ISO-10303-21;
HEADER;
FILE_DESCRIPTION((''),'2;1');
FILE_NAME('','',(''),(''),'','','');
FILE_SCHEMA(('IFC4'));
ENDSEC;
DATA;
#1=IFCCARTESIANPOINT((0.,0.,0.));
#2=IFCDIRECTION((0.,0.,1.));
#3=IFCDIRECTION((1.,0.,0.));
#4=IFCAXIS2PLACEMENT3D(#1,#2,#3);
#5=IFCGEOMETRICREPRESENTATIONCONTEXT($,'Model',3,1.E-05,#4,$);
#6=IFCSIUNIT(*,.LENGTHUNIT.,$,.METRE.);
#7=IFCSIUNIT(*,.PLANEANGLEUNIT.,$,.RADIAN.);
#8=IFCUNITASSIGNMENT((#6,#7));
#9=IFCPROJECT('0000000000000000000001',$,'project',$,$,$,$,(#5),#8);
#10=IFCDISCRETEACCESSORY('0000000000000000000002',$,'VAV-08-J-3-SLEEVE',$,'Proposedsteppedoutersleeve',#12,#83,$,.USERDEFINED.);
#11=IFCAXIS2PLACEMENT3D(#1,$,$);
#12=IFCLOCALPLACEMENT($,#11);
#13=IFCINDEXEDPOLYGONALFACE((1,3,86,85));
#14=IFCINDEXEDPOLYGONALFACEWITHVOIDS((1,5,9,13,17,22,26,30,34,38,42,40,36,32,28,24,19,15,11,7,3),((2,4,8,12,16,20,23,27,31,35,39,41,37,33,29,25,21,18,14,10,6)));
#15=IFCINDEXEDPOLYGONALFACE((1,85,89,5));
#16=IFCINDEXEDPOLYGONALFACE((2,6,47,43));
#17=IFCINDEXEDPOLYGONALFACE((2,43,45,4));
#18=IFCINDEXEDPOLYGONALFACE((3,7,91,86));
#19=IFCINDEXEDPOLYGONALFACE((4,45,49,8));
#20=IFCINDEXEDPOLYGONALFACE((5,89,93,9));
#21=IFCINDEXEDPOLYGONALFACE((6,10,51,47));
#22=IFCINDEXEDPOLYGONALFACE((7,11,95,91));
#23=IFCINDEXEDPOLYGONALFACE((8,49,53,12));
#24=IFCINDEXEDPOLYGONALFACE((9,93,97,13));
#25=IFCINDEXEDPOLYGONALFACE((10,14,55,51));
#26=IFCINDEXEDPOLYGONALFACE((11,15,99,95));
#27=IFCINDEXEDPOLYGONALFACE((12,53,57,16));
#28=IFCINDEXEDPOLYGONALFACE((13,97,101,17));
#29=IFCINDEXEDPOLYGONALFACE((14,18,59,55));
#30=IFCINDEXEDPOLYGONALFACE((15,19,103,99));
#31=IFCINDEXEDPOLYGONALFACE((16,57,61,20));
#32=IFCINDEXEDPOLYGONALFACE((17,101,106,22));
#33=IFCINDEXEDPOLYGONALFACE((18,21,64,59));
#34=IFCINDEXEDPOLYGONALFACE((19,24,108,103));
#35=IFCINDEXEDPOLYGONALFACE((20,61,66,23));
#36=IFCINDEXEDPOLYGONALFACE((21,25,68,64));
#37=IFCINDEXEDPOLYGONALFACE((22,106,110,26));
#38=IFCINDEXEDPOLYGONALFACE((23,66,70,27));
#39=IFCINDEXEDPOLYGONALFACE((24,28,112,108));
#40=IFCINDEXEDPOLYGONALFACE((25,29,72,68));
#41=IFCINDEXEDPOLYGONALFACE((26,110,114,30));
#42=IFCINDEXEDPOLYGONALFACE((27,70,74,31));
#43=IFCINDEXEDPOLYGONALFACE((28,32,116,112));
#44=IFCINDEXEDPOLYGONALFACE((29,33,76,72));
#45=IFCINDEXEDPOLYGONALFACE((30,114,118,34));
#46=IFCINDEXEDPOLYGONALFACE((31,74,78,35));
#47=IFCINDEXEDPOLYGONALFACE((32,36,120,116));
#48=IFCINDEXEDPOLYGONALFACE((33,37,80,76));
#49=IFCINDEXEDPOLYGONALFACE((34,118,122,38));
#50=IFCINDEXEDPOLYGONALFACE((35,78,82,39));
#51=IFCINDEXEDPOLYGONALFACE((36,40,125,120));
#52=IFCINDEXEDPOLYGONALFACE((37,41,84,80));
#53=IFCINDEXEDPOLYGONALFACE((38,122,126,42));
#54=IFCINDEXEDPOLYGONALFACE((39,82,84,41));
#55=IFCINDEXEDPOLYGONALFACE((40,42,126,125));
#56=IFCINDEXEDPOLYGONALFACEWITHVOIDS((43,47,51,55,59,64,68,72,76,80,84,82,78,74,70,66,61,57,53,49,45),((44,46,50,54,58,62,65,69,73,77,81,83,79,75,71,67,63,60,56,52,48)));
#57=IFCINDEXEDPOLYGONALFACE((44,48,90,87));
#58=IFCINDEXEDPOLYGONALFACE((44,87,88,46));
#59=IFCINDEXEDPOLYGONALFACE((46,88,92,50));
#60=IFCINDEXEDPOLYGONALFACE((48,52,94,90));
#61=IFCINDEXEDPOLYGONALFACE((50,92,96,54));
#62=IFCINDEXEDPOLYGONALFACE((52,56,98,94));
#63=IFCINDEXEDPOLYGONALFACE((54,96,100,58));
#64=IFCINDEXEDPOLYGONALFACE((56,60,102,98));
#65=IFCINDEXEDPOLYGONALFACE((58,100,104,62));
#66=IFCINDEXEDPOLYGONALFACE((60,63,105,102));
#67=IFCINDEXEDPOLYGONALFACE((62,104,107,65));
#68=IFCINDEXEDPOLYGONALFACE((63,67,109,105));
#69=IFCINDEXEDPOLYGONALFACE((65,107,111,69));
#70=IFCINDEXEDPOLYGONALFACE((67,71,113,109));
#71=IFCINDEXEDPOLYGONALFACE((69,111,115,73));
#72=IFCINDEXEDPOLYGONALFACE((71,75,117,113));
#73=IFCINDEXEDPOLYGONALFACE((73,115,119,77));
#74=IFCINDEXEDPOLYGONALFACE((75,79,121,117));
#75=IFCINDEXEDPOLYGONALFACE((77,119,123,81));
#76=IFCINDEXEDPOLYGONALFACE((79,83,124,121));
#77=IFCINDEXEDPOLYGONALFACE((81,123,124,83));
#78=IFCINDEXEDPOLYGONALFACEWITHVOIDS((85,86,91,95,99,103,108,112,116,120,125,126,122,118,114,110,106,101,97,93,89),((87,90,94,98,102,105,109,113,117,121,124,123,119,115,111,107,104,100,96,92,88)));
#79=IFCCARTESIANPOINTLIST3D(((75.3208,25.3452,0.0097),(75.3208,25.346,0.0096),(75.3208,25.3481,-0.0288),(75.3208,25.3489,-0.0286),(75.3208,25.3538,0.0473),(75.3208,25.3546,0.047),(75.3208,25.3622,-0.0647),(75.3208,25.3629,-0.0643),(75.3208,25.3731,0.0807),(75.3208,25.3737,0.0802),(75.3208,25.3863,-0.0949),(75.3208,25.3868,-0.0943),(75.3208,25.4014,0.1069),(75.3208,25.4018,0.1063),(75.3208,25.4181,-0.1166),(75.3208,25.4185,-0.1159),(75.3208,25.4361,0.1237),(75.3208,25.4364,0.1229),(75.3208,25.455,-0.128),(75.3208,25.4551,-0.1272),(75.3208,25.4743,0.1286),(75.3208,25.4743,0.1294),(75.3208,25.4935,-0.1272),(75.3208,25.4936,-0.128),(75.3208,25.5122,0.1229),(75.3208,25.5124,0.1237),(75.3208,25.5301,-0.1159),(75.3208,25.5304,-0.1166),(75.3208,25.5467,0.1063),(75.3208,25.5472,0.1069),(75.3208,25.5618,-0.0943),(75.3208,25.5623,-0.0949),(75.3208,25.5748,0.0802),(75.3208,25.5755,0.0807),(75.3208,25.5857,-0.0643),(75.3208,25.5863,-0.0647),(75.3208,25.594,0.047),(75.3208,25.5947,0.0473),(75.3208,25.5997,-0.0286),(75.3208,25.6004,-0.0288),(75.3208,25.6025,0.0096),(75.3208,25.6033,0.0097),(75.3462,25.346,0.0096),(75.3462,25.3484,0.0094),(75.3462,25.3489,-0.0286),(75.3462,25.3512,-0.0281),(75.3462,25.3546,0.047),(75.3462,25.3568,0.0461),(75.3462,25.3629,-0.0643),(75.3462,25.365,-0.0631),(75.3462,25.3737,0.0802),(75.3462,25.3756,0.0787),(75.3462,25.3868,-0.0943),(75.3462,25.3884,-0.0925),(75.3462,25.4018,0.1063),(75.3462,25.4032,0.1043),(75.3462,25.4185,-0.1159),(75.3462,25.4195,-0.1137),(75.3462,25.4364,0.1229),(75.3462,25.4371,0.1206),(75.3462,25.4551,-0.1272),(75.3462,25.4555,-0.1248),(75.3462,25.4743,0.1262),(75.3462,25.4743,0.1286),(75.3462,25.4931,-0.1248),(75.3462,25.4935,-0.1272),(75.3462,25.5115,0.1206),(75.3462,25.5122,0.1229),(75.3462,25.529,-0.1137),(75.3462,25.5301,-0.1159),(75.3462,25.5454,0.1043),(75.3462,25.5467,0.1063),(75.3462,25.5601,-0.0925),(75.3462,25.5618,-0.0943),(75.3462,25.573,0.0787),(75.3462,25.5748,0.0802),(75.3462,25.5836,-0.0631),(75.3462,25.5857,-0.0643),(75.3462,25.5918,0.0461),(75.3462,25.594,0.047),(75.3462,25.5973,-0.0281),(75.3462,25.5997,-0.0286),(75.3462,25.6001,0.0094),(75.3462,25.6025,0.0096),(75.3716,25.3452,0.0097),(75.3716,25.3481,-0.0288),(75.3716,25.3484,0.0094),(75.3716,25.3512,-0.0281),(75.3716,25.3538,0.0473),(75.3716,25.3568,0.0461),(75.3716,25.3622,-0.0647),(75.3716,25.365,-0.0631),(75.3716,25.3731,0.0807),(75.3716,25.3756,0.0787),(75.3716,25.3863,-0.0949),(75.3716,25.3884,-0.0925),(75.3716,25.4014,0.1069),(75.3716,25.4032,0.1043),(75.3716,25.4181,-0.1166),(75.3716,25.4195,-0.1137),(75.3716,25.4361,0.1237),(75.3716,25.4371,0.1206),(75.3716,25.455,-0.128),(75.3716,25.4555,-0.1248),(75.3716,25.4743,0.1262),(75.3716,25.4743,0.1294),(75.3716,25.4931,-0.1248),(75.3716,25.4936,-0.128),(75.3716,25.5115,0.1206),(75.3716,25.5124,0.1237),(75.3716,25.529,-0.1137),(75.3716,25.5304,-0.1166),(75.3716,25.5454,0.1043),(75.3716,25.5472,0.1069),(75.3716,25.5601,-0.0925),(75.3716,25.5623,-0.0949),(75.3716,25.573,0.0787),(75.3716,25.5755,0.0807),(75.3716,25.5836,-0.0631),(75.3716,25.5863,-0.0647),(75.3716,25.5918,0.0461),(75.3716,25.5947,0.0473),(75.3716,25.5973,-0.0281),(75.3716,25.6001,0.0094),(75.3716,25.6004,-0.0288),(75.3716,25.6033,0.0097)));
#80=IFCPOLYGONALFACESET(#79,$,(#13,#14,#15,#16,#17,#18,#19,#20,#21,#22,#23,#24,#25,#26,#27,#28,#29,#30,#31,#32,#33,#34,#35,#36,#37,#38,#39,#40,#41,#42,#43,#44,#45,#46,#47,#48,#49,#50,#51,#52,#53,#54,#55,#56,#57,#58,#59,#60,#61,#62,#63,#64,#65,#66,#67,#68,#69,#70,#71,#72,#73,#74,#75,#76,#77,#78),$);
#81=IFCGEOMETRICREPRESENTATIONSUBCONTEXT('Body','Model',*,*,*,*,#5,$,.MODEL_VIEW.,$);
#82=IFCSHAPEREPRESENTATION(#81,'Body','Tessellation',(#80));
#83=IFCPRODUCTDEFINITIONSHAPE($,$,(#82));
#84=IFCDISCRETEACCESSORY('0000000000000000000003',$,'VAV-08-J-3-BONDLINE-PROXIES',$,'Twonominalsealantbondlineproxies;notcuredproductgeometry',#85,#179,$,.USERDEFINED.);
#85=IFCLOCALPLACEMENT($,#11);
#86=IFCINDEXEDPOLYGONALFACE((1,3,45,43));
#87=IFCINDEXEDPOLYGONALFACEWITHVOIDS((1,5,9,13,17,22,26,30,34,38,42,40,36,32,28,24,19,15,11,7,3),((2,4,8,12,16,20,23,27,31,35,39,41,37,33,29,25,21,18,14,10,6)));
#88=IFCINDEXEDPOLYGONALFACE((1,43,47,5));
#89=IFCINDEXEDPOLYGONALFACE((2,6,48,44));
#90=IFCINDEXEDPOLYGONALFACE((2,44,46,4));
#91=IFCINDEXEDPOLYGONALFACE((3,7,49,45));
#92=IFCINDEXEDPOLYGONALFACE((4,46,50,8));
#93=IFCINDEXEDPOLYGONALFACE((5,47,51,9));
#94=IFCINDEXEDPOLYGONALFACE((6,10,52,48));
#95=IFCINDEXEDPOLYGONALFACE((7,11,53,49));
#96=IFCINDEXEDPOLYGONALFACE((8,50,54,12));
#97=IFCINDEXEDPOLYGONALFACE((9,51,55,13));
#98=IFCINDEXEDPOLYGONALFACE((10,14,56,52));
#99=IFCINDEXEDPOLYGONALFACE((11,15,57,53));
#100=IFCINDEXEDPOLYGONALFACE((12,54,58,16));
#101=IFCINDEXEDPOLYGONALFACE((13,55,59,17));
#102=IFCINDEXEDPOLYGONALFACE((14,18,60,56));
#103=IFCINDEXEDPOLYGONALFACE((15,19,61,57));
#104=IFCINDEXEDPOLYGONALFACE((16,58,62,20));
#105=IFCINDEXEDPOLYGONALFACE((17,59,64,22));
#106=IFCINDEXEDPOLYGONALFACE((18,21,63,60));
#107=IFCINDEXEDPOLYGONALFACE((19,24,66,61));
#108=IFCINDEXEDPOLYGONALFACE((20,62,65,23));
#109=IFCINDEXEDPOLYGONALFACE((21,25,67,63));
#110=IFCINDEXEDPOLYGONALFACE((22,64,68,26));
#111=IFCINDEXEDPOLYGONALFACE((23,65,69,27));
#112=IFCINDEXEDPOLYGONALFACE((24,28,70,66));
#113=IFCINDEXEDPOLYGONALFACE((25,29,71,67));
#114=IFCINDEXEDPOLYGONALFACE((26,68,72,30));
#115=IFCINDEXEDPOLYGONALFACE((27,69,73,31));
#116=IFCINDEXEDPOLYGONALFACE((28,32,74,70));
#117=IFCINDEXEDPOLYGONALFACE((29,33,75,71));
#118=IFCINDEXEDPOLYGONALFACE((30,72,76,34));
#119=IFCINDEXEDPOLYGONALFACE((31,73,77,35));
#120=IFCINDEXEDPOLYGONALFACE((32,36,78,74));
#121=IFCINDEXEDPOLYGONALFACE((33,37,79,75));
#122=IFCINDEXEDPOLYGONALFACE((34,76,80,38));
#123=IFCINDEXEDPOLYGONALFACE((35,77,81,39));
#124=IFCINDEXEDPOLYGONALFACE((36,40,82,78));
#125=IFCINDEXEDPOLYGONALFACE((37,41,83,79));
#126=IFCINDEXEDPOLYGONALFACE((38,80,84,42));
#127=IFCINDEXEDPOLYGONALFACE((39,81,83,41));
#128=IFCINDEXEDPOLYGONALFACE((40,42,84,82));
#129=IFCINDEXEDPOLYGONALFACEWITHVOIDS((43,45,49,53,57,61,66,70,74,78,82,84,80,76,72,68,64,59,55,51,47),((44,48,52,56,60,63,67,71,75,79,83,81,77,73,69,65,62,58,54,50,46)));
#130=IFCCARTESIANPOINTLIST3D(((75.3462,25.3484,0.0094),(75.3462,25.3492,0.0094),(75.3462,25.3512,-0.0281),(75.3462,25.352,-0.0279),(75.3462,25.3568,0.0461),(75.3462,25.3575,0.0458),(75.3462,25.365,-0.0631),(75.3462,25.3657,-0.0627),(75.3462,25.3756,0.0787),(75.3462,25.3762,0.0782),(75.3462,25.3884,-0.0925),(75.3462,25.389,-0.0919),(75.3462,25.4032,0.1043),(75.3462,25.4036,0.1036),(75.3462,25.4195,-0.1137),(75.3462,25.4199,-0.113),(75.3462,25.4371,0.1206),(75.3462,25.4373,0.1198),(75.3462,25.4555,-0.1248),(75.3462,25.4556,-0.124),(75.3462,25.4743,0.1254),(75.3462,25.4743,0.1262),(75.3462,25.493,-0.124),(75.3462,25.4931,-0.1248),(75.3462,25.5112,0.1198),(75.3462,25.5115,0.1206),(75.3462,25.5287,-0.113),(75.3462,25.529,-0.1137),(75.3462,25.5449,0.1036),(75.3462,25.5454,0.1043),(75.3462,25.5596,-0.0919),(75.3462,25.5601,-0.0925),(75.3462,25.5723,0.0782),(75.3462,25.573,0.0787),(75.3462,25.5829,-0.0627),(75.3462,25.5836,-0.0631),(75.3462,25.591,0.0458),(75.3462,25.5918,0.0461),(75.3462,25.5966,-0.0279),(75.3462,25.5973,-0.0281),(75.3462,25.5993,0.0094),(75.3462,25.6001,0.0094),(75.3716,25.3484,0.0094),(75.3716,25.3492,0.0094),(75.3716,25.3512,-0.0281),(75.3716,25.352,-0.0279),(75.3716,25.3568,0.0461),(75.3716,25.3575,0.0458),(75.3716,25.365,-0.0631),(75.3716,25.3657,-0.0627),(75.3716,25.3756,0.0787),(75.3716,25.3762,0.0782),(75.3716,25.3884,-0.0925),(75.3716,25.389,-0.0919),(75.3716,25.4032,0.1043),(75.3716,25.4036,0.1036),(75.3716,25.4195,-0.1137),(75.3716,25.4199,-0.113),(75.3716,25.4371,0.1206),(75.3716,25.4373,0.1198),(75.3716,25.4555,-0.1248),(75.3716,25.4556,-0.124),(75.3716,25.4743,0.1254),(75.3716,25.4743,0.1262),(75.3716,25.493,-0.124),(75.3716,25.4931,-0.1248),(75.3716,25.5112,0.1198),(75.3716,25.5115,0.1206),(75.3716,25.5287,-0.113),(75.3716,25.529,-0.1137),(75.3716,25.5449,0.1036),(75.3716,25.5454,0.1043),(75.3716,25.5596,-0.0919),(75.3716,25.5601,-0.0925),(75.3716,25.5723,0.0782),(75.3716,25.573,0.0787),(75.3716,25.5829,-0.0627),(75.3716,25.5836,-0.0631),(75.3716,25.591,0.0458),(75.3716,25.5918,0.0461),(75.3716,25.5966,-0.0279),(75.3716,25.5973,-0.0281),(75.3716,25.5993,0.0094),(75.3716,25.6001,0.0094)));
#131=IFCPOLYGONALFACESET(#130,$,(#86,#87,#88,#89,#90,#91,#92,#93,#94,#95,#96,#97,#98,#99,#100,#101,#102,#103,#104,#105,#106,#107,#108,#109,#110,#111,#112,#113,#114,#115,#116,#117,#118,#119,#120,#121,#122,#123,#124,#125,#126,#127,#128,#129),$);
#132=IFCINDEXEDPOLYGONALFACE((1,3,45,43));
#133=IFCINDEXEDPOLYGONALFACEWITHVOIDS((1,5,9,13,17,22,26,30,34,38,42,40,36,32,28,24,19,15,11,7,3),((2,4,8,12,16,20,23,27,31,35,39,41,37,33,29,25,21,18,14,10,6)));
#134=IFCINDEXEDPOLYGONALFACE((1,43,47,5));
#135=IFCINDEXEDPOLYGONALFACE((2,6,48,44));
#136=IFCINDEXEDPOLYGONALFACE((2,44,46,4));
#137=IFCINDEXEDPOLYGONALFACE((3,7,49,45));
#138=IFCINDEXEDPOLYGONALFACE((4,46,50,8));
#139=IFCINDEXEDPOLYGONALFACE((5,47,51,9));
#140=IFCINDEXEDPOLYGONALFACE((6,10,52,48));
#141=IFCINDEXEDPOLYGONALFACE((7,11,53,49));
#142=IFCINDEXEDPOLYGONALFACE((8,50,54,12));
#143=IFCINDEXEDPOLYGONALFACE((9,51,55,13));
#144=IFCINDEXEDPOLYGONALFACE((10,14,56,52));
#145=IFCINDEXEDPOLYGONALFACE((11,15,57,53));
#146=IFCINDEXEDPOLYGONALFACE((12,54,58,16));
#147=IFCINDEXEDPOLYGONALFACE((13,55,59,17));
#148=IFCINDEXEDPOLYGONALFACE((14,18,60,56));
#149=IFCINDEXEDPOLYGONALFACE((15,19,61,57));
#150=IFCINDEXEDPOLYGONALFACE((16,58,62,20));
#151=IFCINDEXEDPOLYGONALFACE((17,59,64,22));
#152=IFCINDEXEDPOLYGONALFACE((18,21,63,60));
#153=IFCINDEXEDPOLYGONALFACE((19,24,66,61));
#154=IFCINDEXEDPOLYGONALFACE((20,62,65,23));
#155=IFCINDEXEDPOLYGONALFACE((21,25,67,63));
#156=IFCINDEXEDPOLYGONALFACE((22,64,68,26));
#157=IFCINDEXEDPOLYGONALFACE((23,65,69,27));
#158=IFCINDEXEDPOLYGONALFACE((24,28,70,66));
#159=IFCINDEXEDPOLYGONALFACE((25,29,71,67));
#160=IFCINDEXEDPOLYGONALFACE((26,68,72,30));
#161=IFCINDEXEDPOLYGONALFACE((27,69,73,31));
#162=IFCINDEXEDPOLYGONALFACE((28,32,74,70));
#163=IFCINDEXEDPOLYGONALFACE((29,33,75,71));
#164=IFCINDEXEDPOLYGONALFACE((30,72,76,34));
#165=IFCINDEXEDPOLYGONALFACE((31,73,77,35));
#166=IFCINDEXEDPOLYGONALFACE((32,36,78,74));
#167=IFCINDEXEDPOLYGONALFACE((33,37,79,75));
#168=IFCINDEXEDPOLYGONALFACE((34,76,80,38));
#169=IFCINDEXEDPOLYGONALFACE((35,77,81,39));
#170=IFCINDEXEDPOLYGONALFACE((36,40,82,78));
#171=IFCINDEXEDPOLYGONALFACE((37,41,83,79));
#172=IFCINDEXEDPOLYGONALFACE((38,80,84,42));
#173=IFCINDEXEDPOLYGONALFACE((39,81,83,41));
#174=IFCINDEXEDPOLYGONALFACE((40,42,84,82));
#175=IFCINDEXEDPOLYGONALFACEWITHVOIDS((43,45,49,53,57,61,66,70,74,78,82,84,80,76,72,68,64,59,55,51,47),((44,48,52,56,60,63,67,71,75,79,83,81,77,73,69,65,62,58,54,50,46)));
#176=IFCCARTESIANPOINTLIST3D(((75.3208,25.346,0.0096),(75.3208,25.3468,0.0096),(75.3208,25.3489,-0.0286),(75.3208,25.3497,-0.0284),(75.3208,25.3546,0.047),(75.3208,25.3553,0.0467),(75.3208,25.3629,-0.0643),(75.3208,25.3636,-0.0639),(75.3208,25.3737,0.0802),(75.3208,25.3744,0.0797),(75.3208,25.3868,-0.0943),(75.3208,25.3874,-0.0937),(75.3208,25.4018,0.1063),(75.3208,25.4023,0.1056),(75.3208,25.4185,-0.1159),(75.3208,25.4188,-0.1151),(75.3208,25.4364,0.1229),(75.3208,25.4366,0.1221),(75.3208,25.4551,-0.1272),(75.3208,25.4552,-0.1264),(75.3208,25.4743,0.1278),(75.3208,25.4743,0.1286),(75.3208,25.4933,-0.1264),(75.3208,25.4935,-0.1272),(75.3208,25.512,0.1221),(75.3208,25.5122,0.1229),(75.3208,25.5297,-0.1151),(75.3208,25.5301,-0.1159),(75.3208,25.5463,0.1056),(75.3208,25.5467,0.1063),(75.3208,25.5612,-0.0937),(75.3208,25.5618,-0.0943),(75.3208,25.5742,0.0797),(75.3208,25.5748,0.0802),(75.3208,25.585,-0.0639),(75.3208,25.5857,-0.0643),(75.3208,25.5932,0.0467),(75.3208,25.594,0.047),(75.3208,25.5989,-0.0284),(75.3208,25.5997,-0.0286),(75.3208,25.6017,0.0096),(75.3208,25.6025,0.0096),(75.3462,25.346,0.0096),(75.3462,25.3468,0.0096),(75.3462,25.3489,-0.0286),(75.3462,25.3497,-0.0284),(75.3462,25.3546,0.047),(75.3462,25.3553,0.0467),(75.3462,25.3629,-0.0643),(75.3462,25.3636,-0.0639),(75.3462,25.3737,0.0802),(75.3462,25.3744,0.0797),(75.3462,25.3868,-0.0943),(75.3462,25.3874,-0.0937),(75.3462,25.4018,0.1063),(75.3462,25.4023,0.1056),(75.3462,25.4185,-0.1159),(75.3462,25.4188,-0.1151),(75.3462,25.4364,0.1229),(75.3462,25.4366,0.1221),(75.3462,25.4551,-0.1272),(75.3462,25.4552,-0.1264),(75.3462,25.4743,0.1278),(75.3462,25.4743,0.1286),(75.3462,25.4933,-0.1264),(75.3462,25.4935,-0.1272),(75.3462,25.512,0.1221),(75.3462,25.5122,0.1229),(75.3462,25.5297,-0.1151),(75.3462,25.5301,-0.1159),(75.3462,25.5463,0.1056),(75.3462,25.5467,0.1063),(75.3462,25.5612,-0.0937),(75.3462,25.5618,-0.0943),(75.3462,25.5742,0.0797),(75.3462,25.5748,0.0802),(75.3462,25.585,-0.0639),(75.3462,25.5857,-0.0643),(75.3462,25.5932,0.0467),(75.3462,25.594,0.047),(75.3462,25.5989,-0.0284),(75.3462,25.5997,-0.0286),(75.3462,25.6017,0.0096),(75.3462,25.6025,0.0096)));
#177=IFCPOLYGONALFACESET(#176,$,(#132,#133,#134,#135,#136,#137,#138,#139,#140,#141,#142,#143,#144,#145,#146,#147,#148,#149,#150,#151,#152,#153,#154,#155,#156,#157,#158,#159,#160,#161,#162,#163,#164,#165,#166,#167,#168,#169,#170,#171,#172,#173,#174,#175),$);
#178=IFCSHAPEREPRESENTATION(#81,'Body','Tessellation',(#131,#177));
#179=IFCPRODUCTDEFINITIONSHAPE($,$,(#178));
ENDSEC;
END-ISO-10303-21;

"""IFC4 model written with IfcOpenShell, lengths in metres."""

from ifc_helpers import new_model, entity, si_unit, frame, origin_with_axes, place, context, subcontext, project, element, save


model = new_model("IFC4")

# Units and contexts
model_context = context("Model", 3, precision=1e-05, world=origin_with_axes())
body_context = subcontext(model_context, "Body", "Model", "MODEL_VIEW")
ifc_project = project(units=[si_unit("LENGTHUNIT", "METRE"), si_unit("PLANEANGLEUNIT", "RADIAN")], contexts=[model_context])

# Discrete accessories
discrete_accessory_1_placement = place(None, frame((75.3462, 25.4743, 0.0), z_axis=(0.0, -1.0, 0.0), x_axis=(0.0, 0.0, 1.0)))
element("IfcDiscreteAccessory", 1, at=discrete_accessory_1_placement, Name="VAV-08-J-3-SLEEVE", ObjectType="Proposedsteppedoutersleeve", PredefinedType="USERDEFINED", context=body_context, shape_type="SweptSolid", body=[
    entity("IfcRevolvedAreaSolid", entity("IfcArbitraryClosedProfileDef", "AREA", None, entity("IfcPolyline", [entity("IfcCartesianPoint", [0.1262, -0.0254]), entity("IfcCartesianPoint", [0.1294, -0.0254]), entity("IfcCartesianPoint", [0.1294, 0.0254]), entity("IfcCartesianPoint", [0.1286, 0.0254]), entity("IfcCartesianPoint", [0.1286, 0.0]), entity("IfcCartesianPoint", [0.1262, 0.0]), entity("IfcCartesianPoint", [0.1262, -0.0254])])), entity("IfcAxis2Placement3D", entity("IfcCartesianPoint", [0.0, 0.0, 0.0])), entity("IfcAxis1Placement", entity("IfcCartesianPoint", [0.0, 0.0, 0.0]), entity("IfcDirection", [0.0, 1.0, 0.0])), 6.283185),
])
discrete_accessory_2_placement = place(None, frame((75.3462, 25.4743, 0.0), z_axis=(0.0, -1.0, 0.0), x_axis=(0.0, 0.0, 1.0)))
element("IfcDiscreteAccessory", 2, at=discrete_accessory_2_placement, Name="VAV-08-J-3-BONDLINE-PROXIES", ObjectType="Twonominalsealantbondlineproxies;notcuredproductgeometry", PredefinedType="USERDEFINED", context=body_context, shape_type="SweptSolid", body=[
    entity("IfcRevolvedAreaSolid", entity("IfcArbitraryClosedProfileDef", "AREA", None, entity("IfcPolyline", [entity("IfcCartesianPoint", [0.1254, -0.0254]), entity("IfcCartesianPoint", [0.1262, -0.0254]), entity("IfcCartesianPoint", [0.1262, 0.0]), entity("IfcCartesianPoint", [0.1254, 0.0]), entity("IfcCartesianPoint", [0.1254, -0.0254])])), entity("IfcAxis2Placement3D", entity("IfcCartesianPoint", [0.0, 0.0, 0.0])), entity("IfcAxis1Placement", entity("IfcCartesianPoint", [0.0, 0.0, 0.0]), entity("IfcDirection", [0.0, 1.0, 0.0])), 6.283185),
    entity("IfcRevolvedAreaSolid", entity("IfcArbitraryClosedProfileDef", "AREA", None, entity("IfcPolyline", [entity("IfcCartesianPoint", [0.1278, 0.0]), entity("IfcCartesianPoint", [0.1286, 0.0]), entity("IfcCartesianPoint", [0.1286, 0.0254]), entity("IfcCartesianPoint", [0.1278, 0.0254]), entity("IfcCartesianPoint", [0.1278, 0.0])])), entity("IfcAxis2Placement3D", entity("IfcCartesianPoint", [0.0, 0.0, 0.0])), entity("IfcAxis1Placement", entity("IfcCartesianPoint", [0.0, 0.0, 0.0]), entity("IfcDirection", [0.0, 1.0, 0.0])), 6.283185),
])

save(model, "model.ifc")
